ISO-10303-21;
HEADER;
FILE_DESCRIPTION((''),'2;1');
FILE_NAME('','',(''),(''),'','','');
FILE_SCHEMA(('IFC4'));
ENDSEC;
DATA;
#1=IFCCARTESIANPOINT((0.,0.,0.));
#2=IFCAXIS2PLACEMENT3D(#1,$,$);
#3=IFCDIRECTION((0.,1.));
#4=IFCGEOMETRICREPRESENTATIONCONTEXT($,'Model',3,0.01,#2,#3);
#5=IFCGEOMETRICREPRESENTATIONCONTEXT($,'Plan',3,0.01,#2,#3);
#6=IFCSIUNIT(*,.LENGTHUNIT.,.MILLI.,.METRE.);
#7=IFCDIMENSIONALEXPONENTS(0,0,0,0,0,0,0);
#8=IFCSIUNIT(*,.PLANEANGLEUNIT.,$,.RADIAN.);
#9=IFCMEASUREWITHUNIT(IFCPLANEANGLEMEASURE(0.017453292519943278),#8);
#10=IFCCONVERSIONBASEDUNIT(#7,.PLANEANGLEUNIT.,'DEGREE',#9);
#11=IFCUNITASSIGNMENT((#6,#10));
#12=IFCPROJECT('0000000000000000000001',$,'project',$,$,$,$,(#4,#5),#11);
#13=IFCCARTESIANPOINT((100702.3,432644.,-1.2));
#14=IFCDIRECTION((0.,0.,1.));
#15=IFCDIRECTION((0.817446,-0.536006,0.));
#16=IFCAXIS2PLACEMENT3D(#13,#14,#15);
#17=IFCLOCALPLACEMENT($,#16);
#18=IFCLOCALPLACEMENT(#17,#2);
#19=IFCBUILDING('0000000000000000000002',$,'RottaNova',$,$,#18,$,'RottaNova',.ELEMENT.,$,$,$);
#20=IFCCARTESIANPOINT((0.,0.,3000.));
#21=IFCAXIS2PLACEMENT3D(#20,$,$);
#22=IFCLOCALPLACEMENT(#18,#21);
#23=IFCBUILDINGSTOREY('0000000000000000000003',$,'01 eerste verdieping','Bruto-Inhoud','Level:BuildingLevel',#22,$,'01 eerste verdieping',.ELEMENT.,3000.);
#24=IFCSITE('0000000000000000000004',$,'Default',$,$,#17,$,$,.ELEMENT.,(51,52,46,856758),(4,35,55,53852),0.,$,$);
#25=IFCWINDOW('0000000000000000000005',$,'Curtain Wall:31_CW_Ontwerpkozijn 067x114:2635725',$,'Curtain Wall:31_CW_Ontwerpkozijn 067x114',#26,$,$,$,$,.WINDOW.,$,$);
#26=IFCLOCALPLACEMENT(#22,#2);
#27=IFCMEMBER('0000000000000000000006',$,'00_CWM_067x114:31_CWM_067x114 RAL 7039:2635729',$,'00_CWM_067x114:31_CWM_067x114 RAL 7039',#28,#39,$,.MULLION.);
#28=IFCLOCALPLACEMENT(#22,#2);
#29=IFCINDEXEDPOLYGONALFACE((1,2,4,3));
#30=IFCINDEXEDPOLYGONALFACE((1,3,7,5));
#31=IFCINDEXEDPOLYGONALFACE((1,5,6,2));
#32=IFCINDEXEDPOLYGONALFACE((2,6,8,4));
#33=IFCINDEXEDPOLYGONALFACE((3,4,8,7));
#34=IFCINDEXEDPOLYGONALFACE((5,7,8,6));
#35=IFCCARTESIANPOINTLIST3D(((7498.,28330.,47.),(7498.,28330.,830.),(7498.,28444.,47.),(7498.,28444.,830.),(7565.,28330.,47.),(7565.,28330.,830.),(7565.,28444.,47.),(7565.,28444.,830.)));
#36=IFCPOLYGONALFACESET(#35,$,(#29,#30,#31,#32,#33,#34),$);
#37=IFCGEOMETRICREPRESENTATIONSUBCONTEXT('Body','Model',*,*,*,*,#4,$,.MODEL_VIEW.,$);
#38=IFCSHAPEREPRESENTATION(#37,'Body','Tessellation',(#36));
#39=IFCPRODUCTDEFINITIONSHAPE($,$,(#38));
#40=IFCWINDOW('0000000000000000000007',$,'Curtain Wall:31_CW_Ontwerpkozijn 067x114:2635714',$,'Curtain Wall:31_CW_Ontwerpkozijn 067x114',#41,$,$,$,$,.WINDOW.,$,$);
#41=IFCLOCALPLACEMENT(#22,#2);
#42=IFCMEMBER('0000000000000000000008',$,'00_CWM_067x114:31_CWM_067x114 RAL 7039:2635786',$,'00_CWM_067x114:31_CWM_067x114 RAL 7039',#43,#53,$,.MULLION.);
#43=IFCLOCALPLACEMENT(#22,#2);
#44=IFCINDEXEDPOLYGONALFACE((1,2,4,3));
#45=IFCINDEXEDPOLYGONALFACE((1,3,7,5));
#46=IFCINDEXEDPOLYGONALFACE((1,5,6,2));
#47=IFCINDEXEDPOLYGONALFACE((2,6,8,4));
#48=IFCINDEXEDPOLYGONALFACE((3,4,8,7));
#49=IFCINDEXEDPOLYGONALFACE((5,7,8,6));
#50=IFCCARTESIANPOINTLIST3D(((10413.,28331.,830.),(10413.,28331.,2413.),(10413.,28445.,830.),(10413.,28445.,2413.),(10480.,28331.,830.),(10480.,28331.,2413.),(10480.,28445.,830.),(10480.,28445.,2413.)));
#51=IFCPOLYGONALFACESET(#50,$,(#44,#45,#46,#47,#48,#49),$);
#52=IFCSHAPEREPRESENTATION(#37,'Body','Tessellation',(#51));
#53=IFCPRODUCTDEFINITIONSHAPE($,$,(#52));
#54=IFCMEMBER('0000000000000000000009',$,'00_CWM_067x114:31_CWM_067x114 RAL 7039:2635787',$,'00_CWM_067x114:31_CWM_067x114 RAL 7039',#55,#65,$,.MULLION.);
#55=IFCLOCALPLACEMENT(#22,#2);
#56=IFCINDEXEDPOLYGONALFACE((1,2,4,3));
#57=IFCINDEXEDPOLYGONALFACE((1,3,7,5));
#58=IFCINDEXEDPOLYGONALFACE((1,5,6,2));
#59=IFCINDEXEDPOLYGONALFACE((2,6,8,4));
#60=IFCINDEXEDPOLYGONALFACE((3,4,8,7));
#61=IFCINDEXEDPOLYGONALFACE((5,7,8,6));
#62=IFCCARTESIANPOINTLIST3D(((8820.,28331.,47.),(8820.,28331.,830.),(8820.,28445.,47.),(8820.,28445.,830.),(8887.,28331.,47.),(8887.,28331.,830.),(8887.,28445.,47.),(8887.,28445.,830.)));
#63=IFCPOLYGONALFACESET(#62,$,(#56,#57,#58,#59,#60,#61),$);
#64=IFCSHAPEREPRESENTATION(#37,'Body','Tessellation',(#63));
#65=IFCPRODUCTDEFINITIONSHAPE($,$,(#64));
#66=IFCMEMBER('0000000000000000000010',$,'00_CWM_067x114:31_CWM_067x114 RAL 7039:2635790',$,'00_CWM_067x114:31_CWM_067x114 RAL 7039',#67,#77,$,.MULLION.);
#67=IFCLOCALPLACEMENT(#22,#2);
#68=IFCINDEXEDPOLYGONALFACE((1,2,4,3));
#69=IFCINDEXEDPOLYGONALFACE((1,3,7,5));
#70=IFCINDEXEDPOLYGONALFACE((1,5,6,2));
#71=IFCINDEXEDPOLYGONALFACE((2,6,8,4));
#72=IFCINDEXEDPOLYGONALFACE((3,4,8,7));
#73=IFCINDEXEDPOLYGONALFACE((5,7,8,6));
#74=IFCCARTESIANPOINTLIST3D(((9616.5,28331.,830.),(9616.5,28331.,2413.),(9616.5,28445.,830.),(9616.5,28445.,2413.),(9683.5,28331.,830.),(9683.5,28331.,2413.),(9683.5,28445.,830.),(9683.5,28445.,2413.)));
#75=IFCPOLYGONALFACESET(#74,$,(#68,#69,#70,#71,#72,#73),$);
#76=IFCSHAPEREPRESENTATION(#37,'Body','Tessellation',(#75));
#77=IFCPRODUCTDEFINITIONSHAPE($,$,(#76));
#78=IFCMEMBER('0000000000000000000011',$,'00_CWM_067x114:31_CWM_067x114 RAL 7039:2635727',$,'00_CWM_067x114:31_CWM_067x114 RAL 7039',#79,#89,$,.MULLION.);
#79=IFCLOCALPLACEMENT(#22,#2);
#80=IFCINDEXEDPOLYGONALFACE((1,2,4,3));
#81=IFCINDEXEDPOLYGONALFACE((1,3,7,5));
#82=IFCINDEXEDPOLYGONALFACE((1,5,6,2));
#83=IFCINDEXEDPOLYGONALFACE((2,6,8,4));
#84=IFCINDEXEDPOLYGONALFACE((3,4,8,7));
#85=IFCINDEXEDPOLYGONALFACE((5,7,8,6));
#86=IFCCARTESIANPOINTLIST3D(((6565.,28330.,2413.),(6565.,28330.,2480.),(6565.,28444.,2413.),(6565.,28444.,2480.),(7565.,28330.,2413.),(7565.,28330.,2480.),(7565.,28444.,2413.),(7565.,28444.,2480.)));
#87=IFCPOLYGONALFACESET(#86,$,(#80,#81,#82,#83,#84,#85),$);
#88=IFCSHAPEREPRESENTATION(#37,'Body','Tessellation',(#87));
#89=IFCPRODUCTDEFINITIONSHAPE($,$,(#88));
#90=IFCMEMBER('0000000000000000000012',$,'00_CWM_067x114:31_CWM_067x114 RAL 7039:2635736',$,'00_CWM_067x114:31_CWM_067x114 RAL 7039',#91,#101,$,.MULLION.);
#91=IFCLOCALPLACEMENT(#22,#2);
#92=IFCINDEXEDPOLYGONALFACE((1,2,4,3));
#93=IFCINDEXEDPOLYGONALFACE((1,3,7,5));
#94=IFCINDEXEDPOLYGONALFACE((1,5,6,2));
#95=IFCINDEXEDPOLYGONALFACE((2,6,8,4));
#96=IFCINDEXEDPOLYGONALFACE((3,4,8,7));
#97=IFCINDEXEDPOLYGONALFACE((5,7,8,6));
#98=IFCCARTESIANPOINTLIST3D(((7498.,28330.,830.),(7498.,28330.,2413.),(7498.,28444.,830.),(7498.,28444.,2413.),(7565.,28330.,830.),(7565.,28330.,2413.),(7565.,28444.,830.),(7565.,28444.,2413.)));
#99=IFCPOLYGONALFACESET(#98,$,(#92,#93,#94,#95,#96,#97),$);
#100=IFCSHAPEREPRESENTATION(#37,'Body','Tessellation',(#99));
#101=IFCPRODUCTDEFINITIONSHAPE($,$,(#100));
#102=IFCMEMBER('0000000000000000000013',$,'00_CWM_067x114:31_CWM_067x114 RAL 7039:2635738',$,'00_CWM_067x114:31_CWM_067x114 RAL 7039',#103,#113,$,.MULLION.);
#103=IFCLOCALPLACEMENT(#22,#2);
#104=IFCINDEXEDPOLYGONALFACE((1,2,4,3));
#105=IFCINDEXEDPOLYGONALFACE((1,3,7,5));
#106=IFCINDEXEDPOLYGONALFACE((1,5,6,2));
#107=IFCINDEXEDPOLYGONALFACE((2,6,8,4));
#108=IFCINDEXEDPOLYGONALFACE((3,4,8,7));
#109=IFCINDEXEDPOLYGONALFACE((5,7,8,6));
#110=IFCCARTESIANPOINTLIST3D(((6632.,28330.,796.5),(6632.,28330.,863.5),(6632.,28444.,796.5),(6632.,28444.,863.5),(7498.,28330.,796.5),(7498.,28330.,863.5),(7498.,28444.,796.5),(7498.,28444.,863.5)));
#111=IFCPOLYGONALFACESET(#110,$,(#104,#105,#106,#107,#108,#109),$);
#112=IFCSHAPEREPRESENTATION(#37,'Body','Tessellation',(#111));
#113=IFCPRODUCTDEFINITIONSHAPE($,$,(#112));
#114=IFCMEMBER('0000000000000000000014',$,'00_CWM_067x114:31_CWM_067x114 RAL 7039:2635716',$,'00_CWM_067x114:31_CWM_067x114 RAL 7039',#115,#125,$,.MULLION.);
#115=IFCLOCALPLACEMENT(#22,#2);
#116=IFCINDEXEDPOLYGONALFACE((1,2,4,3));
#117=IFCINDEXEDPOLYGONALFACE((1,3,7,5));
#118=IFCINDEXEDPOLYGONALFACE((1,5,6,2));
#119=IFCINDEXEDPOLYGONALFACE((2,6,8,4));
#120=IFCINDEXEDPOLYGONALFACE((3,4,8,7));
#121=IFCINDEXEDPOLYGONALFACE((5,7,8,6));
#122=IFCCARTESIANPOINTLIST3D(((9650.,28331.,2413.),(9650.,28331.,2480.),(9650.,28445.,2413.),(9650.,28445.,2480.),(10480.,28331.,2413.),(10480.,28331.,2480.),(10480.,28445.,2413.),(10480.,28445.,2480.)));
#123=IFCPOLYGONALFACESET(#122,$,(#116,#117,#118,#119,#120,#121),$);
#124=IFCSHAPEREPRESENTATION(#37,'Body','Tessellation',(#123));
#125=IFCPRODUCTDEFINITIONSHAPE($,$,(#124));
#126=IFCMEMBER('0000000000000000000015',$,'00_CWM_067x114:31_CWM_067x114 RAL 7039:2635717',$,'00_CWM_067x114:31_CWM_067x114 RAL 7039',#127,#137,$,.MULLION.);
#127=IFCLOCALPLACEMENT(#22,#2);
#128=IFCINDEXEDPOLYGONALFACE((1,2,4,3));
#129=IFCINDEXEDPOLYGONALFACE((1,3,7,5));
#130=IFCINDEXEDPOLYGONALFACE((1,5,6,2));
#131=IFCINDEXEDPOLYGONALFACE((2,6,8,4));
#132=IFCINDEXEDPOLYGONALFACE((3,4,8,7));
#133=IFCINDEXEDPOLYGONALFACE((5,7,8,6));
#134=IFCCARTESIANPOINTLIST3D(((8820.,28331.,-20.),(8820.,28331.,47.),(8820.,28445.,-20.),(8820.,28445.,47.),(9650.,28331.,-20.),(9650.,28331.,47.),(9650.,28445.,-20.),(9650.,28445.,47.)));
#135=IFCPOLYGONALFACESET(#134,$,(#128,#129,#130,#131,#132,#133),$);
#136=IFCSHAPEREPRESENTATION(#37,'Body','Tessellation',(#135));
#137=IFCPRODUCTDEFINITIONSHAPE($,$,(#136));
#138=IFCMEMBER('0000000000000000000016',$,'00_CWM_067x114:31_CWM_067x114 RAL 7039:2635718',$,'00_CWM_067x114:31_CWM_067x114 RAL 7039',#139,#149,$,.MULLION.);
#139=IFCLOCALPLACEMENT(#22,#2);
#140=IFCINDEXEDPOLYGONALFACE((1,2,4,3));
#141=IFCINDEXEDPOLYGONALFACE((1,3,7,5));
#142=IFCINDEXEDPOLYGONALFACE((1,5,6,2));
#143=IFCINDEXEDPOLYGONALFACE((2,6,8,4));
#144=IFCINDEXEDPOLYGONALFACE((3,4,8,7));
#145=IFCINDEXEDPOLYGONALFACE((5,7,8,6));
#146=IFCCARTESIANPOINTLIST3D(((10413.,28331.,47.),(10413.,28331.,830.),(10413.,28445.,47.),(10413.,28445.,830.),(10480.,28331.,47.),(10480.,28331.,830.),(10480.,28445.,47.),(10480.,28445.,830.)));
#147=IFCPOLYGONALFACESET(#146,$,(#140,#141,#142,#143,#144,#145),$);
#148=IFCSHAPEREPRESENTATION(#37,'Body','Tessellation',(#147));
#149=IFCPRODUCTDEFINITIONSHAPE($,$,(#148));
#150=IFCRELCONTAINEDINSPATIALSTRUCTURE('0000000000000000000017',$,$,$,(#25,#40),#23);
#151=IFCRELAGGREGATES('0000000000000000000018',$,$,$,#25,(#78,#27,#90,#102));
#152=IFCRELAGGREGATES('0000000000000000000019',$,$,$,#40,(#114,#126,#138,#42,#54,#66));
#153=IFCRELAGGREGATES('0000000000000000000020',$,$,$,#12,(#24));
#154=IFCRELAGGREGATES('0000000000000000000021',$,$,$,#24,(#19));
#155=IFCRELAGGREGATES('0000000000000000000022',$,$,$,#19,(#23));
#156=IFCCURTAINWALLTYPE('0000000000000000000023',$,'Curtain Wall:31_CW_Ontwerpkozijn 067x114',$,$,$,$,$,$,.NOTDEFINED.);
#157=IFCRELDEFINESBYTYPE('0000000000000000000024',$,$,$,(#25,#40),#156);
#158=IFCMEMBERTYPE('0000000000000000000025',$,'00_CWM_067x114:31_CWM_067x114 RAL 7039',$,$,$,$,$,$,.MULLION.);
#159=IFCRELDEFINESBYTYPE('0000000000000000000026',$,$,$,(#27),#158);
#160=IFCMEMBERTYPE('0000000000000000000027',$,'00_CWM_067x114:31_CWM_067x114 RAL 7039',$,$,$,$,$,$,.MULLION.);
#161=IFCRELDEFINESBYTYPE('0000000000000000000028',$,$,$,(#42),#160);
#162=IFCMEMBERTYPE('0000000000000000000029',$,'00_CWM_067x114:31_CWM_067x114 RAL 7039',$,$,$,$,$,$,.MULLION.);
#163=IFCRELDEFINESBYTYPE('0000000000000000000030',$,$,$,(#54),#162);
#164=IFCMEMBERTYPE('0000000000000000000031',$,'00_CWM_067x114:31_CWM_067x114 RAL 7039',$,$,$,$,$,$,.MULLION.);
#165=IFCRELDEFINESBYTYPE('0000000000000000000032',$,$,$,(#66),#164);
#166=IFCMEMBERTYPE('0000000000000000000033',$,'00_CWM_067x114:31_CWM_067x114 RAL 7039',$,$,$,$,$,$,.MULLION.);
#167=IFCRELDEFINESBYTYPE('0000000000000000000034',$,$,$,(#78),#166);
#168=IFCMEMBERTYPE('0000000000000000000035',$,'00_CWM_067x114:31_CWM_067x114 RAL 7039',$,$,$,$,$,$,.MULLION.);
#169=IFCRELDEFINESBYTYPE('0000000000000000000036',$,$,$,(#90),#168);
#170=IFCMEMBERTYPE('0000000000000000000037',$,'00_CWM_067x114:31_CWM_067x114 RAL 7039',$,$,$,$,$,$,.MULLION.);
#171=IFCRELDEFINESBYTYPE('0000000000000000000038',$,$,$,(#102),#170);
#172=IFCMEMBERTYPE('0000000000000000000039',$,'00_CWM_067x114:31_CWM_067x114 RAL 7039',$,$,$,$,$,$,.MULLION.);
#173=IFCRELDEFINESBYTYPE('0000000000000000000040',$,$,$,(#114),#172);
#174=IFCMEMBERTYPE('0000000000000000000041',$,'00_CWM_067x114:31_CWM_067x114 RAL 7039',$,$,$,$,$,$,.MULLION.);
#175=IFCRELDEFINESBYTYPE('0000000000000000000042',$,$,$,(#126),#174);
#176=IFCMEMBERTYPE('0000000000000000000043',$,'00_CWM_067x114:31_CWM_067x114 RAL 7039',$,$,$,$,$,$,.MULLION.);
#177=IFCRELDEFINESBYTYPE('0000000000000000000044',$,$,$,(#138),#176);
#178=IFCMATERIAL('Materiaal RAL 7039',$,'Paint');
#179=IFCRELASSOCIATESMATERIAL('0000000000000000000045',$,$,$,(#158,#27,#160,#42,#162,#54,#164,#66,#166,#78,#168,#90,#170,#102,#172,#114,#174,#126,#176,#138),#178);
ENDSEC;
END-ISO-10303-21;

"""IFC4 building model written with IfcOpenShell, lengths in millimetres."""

from ifc_helpers import new_model, entity, si_unit, converted_unit, direction, frame, origin, place, context, subcontext, project, spatial, indexed_curve, outline, extrude, source, transform, mapped, material, type_object, type_shapes, element, aggregate, save


model = new_model("IFC4")

# Units and contexts
model_context = context("Model", 3, precision=0.01, world=origin(), true_north=direction((0.0, 1.0)))
plan_context = context("Plan", 3, precision=0.01, world=origin(), true_north=direction((0.0, 1.0)))
body_context = subcontext(model_context, "Body", "Model", "MODEL_VIEW")
ifc_project = project(units=[si_unit("LENGTHUNIT", "METRE", prefix="MILLI"), converted_unit("PLANEANGLEUNIT", "DEGREE", entity("IfcPlaneAngleMeasure", 0.017453292519943278), si_unit("PLANEANGLEUNIT", "RADIAN"), dimensions=[0, 0, 0, 0, 0, 0, 0])], contexts=[model_context, plan_context])

# Site, building, storey
site_placement = place(None, frame((100702.3, 432644.0, -1.2), z_axis=(0.0, 0.0, 1.0), x_axis=(0.817446, -0.536006, 0.0)))
site = spatial("IfcSite", under=ifc_project, at=site_placement, Name="Default", CompositionType="ELEMENT", RefLatitude=(51, 52, 46, 856758), RefLongitude=(4, 35, 55, 53852), RefElevation=0.0)
building_placement = place(site_placement, origin())
building = spatial("IfcBuilding", under=site, at=building_placement, Name="RottaNova", LongName="RottaNova", CompositionType="ELEMENT")
storey_placement = place(building_placement, frame((0.0, 0.0, 3000.0)))
storey = spatial("IfcBuildingStorey", under=building, at=storey_placement, Name="01 eerste verdieping", Description="Bruto-Inhoud", ObjectType="Level:BuildingLevel", LongName="01 eerste verdieping", CompositionType="ELEMENT", Elevation=3000.0)

# Window, member
curtain_wall_type = type_object("IfcCurtainWallType", Name="Curtain Wall:31_CW_Ontwerpkozijn 067x114", PredefinedType="NOTDEFINED")
window_1_placement = place(storey_placement, frame((0.0, 0.0, -3000.0)))
window_1 = element("IfcWindow", 1, at=window_1_placement, inside=storey, type_object=curtain_wall_type, Name="Curtain Wall:31_CW_Ontwerpkozijn 067x114:2635725", ObjectType="Curtain Wall:31_CW_Ontwerpkozijn 067x114", PredefinedType="WINDOW")
ifc_material_1 = material(Name="Materiaal RAL 7039", Category="Paint")
member_type_1 = type_object("IfcMemberType", Name="00_CWM_067x114:31_CWM_067x114 RAL 7039", PredefinedType="MULLION", material=ifc_material_1)
shared_shape_1 = source(origin(), body_context, "Body", "SweptSolid", [
    extrude(outline(indexed_curve([(-33.5, -57.0), (33.5, -57.0), (33.5, 57.0), (-33.5, 57.0), (-33.5, -57.0)], self_intersect=False)), frame((-33.5, -57.0, -783.0), z_axis=(0.0, 0.0, 1.0), x_axis=(-1.0, 0.0, 0.0)), (0.0, 0.0, 1.0), 783.0),
])
type_shapes(member_type_1, [shared_shape_1])
member_1_placement = place(window_1_placement, frame((7565.0, 28330.0, 3047.0), z_axis=(0.0, 0.0, -1.0), x_axis=(1.0, 0.0, 0.0)))
member_1 = element("IfcMember", 2, at=member_1_placement, type_object=member_type_1, material=ifc_material_1, Name="00_CWM_067x114:31_CWM_067x114 RAL 7039:2635729", ObjectType="00_CWM_067x114:31_CWM_067x114 RAL 7039", PredefinedType="MULLION", context=body_context, shape_type="MappedRepresentation", body=[
    mapped(shared_shape_1, transform((0.0, 0.0, 0.0), scale=1.0)),
])

# Window, members
window_2_placement = place(storey_placement, frame((0.0, 0.0, -3000.0)))
window_2 = element("IfcWindow", 3, at=window_2_placement, inside=storey, type_object=curtain_wall_type, Name="Curtain Wall:31_CW_Ontwerpkozijn 067x114:2635714", ObjectType="Curtain Wall:31_CW_Ontwerpkozijn 067x114", PredefinedType="WINDOW")
member_type_2 = type_object("IfcMemberType", Name="00_CWM_067x114:31_CWM_067x114 RAL 7039", PredefinedType="MULLION", material=ifc_material_1)
shared_shape_2 = source(origin(), body_context, "Body", "SweptSolid", [
    extrude(outline(indexed_curve([(-33.5, -57.0), (33.5, -57.0), (33.5, 57.0), (-33.5, 57.0), (-33.5, -57.0)], self_intersect=False)), frame((-33.5, -57.0, -1583.0), z_axis=(0.0, 0.0, 1.0), x_axis=(-1.0, 0.0, 0.0)), (0.0, 0.0, 1.0), 1583.0),
])
type_shapes(member_type_2, [shared_shape_2])
member_2_placement = place(window_2_placement, frame((10480.0, 28331.0, 3830.0), z_axis=(0.0, 0.0, -1.0), x_axis=(1.0, 0.0, 0.0)))
member_2 = element("IfcMember", 4, at=member_2_placement, type_object=member_type_2, material=ifc_material_1, Name="00_CWM_067x114:31_CWM_067x114 RAL 7039:2635786", ObjectType="00_CWM_067x114:31_CWM_067x114 RAL 7039", PredefinedType="MULLION", context=body_context, shape_type="MappedRepresentation", body=[
    mapped(shared_shape_2, transform((0.0, 0.0, 0.0), scale=1.0)),
])
member_type_3 = type_object("IfcMemberType", Name="00_CWM_067x114:31_CWM_067x114 RAL 7039", PredefinedType="MULLION", material=ifc_material_1)
shared_shape_3 = source(origin(), body_context, "Body", "SweptSolid", [
    extrude(outline(indexed_curve([(-33.5, -57.0), (33.5, -57.0), (33.5, 57.0), (-33.5, 57.0), (-33.5, -57.0)], self_intersect=False)), frame((-33.5, -57.0, -783.0), z_axis=(0.0, 0.0, 1.0), x_axis=(-1.0, 0.0, 0.0)), (0.0, 0.0, 1.0), 783.0),
])
type_shapes(member_type_3, [shared_shape_3])
member_3_placement = place(window_2_placement, frame((8820.0, 28331.0, 3830.0), z_axis=(0.0, 0.0, 1.0), x_axis=(-1.0, 0.0, 0.0)))
member_3 = element("IfcMember", 5, at=member_3_placement, type_object=member_type_3, material=ifc_material_1, Name="00_CWM_067x114:31_CWM_067x114 RAL 7039:2635787", ObjectType="00_CWM_067x114:31_CWM_067x114 RAL 7039", PredefinedType="MULLION", context=body_context, shape_type="MappedRepresentation", body=[
    mapped(shared_shape_3, transform((0.0, 0.0, 0.0), scale=1.0)),
])
member_type_4 = type_object("IfcMemberType", Name="00_CWM_067x114:31_CWM_067x114 RAL 7039", PredefinedType="MULLION", material=ifc_material_1)
shared_shape_4 = source(origin(), body_context, "Body", "SweptSolid", [
    extrude(outline(indexed_curve([(-33.5, -57.0), (33.5, -57.0), (33.5, 57.0), (-33.5, 57.0), (-33.5, -57.0)], self_intersect=False)), frame((0.0, -57.0, -1583.0), z_axis=(0.0, 0.0, 1.0), x_axis=(-1.0, 0.0, 0.0)), (0.0, 0.0, 1.0), 1583.0),
])
type_shapes(member_type_4, [shared_shape_4])
member_4_placement = place(window_2_placement, frame((9650.0, 28331.0, 3830.0), z_axis=(0.0, 0.0, -1.0), x_axis=(1.0, 0.0, 0.0)))
member_4 = element("IfcMember", 6, at=member_4_placement, type_object=member_type_4, material=ifc_material_1, Name="00_CWM_067x114:31_CWM_067x114 RAL 7039:2635790", ObjectType="00_CWM_067x114:31_CWM_067x114 RAL 7039", PredefinedType="MULLION", context=body_context, shape_type="MappedRepresentation", body=[
    mapped(shared_shape_4, transform((0.0, 0.0, 0.0), scale=1.0)),
])

# Members
member_type_5 = type_object("IfcMemberType", Name="00_CWM_067x114:31_CWM_067x114 RAL 7039", PredefinedType="MULLION", material=ifc_material_1)
shared_shape_5 = source(origin(), body_context, "Body", "SweptSolid", [
    extrude(outline(indexed_curve([(-33.5, -57.0), (33.5, -57.0), (33.5, 57.0), (-33.5, 57.0), (-33.5, -57.0)], self_intersect=False)), frame((-33.5, -57.0, -1000.0), z_axis=(0.0, 0.0, 1.0), x_axis=(-1.0, 0.0, 0.0)), (0.0, 0.0, 1.0), 1000.0),
])
type_shapes(member_type_5, [shared_shape_5])
member_5_placement = place(window_1_placement, frame((7565.0, 28330.0, 5480.0), z_axis=(1.0, 0.0, 0.0), x_axis=(0.0, 0.0, 1.0)))
member_5 = element("IfcMember", 7, at=member_5_placement, type_object=member_type_5, material=ifc_material_1, Name="00_CWM_067x114:31_CWM_067x114 RAL 7039:2635727", ObjectType="00_CWM_067x114:31_CWM_067x114 RAL 7039", PredefinedType="MULLION", context=body_context, shape_type="MappedRepresentation", body=[
    mapped(shared_shape_5, transform((0.0, 0.0, 0.0), scale=1.0)),
])
member_type_6 = type_object("IfcMemberType", Name="00_CWM_067x114:31_CWM_067x114 RAL 7039", PredefinedType="MULLION", material=ifc_material_1)
shared_shape_6 = source(origin(), body_context, "Body", "SweptSolid", [
    extrude(outline(indexed_curve([(-33.5, -57.0), (33.5, -57.0), (33.5, 57.0), (-33.5, 57.0), (-33.5, -57.0)], self_intersect=False)), frame((-33.5, -57.0, -1583.0), z_axis=(0.0, 0.0, 1.0), x_axis=(-1.0, 0.0, 0.0)), (0.0, 0.0, 1.0), 1583.0),
])
type_shapes(member_type_6, [shared_shape_6])
member_6_placement = place(window_1_placement, frame((7565.0, 28330.0, 3830.0), z_axis=(0.0, 0.0, -1.0), x_axis=(1.0, 0.0, 0.0)))
member_6 = element("IfcMember", 8, at=member_6_placement, type_object=member_type_6, material=ifc_material_1, Name="00_CWM_067x114:31_CWM_067x114 RAL 7039:2635736", ObjectType="00_CWM_067x114:31_CWM_067x114 RAL 7039", PredefinedType="MULLION", context=body_context, shape_type="MappedRepresentation", body=[
    mapped(shared_shape_6, transform((0.0, 0.0, 0.0), scale=1.0)),
])
member_type_7 = type_object("IfcMemberType", Name="00_CWM_067x114:31_CWM_067x114 RAL 7039", PredefinedType="MULLION", material=ifc_material_1)
shared_shape_7 = source(origin(), body_context, "Body", "SweptSolid", [
    extrude(outline(indexed_curve([(-33.5, -57.0), (33.5, -57.0), (33.5, 57.0), (-33.5, 57.0), (-33.5, -57.0)], self_intersect=False)), frame((0.0, -57.0, -866.0), z_axis=(0.0, 0.0, 1.0), x_axis=(-1.0, 0.0, 0.0)), (0.0, 0.0, 1.0), 866.0),
])
type_shapes(member_type_7, [shared_shape_7])
member_7_placement = place(window_1_placement, frame((7498.0, 28330.0, 3830.0), z_axis=(1.0, 0.0, 0.0), x_axis=(0.0, 0.0, 1.0)))
member_7 = element("IfcMember", 9, at=member_7_placement, type_object=member_type_7, material=ifc_material_1, Name="00_CWM_067x114:31_CWM_067x114 RAL 7039:2635738", ObjectType="00_CWM_067x114:31_CWM_067x114 RAL 7039", PredefinedType="MULLION", context=body_context, shape_type="MappedRepresentation", body=[
    mapped(shared_shape_7, transform((0.0, 0.0, 0.0), scale=1.0)),
])
aggregate(window_1, [member_5, member_1, member_6, member_7])
member_type_8 = type_object("IfcMemberType", Name="00_CWM_067x114:31_CWM_067x114 RAL 7039", PredefinedType="MULLION", material=ifc_material_1)
shared_shape_8 = source(origin(), body_context, "Body", "SweptSolid", [
    extrude(outline(indexed_curve([(-33.5, -57.0), (33.5, -57.0), (33.5, 57.0), (-33.5, 57.0), (-33.5, -57.0)], self_intersect=False)), frame((-33.5, -57.0, -830.0), z_axis=(0.0, 0.0, 1.0), x_axis=(-1.0, 0.0, 0.0)), (0.0, 0.0, 1.0), 830.0),
])
type_shapes(member_type_8, [shared_shape_8])
member_8_placement = place(window_2_placement, frame((10480.0, 28331.0, 5480.0), z_axis=(1.0, 0.0, 0.0), x_axis=(0.0, 0.0, 1.0)))
member_8 = element("IfcMember", 10, at=member_8_placement, type_object=member_type_8, material=ifc_material_1, Name="00_CWM_067x114:31_CWM_067x114 RAL 7039:2635716", ObjectType="00_CWM_067x114:31_CWM_067x114 RAL 7039", PredefinedType="MULLION", context=body_context, shape_type="MappedRepresentation", body=[
    mapped(shared_shape_8, transform((0.0, 0.0, 0.0), scale=1.0)),
])
member_type_9 = type_object("IfcMemberType", Name="00_CWM_067x114:31_CWM_067x114 RAL 7039", PredefinedType="MULLION", material=ifc_material_1)
shared_shape_9 = source(origin(), body_context, "Body", "SweptSolid", [
    extrude(outline(indexed_curve([(-33.5, -57.0), (33.5, -57.0), (33.5, 57.0), (-33.5, 57.0), (-33.5, -57.0)], self_intersect=False)), frame((-33.5, -57.0, -830.0), z_axis=(0.0, 0.0, 1.0), x_axis=(-1.0, 0.0, 0.0)), (0.0, 0.0, 1.0), 830.0),
])
type_shapes(member_type_9, [shared_shape_9])
member_9_placement = place(window_2_placement, frame((8820.0, 28331.0, 2980.0), z_axis=(-1.0, 0.0, 0.0), x_axis=(0.0, 0.0, -1.0)))
member_9 = element("IfcMember", 11, at=member_9_placement, type_object=member_type_9, material=ifc_material_1, Name="00_CWM_067x114:31_CWM_067x114 RAL 7039:2635717", ObjectType="00_CWM_067x114:31_CWM_067x114 RAL 7039", PredefinedType="MULLION", context=body_context, shape_type="MappedRepresentation", body=[
    mapped(shared_shape_9, transform((0.0, 0.0, 0.0), scale=1.0)),
])
member_type_10 = type_object("IfcMemberType", Name="00_CWM_067x114:31_CWM_067x114 RAL 7039", PredefinedType="MULLION", material=ifc_material_1)
shared_shape_10 = source(origin(), body_context, "Body", "SweptSolid", [
    extrude(outline(indexed_curve([(-33.5, -57.0), (33.5, -57.0), (33.5, 57.0), (-33.5, 57.0), (-33.5, -57.0)], self_intersect=False)), frame((-33.5, -57.0, -783.0), z_axis=(0.0, 0.0, 1.0), x_axis=(-1.0, 0.0, 0.0)), (0.0, 0.0, 1.0), 783.0),
])
type_shapes(member_type_10, [shared_shape_10])
member_10_placement = place(window_2_placement, frame((10480.0, 28331.0, 3047.0), z_axis=(0.0, 0.0, -1.0), x_axis=(1.0, 0.0, 0.0)))
member_10 = element("IfcMember", 12, at=member_10_placement, type_object=member_type_10, material=ifc_material_1, Name="00_CWM_067x114:31_CWM_067x114 RAL 7039:2635718", ObjectType="00_CWM_067x114:31_CWM_067x114 RAL 7039", PredefinedType="MULLION", context=body_context, shape_type="MappedRepresentation", body=[
    mapped(shared_shape_10, transform((0.0, 0.0, 0.0), scale=1.0)),
])

aggregate(window_2, [member_8, member_9, member_10, member_2, member_3, member_4])

save(model, "model.ifc")
